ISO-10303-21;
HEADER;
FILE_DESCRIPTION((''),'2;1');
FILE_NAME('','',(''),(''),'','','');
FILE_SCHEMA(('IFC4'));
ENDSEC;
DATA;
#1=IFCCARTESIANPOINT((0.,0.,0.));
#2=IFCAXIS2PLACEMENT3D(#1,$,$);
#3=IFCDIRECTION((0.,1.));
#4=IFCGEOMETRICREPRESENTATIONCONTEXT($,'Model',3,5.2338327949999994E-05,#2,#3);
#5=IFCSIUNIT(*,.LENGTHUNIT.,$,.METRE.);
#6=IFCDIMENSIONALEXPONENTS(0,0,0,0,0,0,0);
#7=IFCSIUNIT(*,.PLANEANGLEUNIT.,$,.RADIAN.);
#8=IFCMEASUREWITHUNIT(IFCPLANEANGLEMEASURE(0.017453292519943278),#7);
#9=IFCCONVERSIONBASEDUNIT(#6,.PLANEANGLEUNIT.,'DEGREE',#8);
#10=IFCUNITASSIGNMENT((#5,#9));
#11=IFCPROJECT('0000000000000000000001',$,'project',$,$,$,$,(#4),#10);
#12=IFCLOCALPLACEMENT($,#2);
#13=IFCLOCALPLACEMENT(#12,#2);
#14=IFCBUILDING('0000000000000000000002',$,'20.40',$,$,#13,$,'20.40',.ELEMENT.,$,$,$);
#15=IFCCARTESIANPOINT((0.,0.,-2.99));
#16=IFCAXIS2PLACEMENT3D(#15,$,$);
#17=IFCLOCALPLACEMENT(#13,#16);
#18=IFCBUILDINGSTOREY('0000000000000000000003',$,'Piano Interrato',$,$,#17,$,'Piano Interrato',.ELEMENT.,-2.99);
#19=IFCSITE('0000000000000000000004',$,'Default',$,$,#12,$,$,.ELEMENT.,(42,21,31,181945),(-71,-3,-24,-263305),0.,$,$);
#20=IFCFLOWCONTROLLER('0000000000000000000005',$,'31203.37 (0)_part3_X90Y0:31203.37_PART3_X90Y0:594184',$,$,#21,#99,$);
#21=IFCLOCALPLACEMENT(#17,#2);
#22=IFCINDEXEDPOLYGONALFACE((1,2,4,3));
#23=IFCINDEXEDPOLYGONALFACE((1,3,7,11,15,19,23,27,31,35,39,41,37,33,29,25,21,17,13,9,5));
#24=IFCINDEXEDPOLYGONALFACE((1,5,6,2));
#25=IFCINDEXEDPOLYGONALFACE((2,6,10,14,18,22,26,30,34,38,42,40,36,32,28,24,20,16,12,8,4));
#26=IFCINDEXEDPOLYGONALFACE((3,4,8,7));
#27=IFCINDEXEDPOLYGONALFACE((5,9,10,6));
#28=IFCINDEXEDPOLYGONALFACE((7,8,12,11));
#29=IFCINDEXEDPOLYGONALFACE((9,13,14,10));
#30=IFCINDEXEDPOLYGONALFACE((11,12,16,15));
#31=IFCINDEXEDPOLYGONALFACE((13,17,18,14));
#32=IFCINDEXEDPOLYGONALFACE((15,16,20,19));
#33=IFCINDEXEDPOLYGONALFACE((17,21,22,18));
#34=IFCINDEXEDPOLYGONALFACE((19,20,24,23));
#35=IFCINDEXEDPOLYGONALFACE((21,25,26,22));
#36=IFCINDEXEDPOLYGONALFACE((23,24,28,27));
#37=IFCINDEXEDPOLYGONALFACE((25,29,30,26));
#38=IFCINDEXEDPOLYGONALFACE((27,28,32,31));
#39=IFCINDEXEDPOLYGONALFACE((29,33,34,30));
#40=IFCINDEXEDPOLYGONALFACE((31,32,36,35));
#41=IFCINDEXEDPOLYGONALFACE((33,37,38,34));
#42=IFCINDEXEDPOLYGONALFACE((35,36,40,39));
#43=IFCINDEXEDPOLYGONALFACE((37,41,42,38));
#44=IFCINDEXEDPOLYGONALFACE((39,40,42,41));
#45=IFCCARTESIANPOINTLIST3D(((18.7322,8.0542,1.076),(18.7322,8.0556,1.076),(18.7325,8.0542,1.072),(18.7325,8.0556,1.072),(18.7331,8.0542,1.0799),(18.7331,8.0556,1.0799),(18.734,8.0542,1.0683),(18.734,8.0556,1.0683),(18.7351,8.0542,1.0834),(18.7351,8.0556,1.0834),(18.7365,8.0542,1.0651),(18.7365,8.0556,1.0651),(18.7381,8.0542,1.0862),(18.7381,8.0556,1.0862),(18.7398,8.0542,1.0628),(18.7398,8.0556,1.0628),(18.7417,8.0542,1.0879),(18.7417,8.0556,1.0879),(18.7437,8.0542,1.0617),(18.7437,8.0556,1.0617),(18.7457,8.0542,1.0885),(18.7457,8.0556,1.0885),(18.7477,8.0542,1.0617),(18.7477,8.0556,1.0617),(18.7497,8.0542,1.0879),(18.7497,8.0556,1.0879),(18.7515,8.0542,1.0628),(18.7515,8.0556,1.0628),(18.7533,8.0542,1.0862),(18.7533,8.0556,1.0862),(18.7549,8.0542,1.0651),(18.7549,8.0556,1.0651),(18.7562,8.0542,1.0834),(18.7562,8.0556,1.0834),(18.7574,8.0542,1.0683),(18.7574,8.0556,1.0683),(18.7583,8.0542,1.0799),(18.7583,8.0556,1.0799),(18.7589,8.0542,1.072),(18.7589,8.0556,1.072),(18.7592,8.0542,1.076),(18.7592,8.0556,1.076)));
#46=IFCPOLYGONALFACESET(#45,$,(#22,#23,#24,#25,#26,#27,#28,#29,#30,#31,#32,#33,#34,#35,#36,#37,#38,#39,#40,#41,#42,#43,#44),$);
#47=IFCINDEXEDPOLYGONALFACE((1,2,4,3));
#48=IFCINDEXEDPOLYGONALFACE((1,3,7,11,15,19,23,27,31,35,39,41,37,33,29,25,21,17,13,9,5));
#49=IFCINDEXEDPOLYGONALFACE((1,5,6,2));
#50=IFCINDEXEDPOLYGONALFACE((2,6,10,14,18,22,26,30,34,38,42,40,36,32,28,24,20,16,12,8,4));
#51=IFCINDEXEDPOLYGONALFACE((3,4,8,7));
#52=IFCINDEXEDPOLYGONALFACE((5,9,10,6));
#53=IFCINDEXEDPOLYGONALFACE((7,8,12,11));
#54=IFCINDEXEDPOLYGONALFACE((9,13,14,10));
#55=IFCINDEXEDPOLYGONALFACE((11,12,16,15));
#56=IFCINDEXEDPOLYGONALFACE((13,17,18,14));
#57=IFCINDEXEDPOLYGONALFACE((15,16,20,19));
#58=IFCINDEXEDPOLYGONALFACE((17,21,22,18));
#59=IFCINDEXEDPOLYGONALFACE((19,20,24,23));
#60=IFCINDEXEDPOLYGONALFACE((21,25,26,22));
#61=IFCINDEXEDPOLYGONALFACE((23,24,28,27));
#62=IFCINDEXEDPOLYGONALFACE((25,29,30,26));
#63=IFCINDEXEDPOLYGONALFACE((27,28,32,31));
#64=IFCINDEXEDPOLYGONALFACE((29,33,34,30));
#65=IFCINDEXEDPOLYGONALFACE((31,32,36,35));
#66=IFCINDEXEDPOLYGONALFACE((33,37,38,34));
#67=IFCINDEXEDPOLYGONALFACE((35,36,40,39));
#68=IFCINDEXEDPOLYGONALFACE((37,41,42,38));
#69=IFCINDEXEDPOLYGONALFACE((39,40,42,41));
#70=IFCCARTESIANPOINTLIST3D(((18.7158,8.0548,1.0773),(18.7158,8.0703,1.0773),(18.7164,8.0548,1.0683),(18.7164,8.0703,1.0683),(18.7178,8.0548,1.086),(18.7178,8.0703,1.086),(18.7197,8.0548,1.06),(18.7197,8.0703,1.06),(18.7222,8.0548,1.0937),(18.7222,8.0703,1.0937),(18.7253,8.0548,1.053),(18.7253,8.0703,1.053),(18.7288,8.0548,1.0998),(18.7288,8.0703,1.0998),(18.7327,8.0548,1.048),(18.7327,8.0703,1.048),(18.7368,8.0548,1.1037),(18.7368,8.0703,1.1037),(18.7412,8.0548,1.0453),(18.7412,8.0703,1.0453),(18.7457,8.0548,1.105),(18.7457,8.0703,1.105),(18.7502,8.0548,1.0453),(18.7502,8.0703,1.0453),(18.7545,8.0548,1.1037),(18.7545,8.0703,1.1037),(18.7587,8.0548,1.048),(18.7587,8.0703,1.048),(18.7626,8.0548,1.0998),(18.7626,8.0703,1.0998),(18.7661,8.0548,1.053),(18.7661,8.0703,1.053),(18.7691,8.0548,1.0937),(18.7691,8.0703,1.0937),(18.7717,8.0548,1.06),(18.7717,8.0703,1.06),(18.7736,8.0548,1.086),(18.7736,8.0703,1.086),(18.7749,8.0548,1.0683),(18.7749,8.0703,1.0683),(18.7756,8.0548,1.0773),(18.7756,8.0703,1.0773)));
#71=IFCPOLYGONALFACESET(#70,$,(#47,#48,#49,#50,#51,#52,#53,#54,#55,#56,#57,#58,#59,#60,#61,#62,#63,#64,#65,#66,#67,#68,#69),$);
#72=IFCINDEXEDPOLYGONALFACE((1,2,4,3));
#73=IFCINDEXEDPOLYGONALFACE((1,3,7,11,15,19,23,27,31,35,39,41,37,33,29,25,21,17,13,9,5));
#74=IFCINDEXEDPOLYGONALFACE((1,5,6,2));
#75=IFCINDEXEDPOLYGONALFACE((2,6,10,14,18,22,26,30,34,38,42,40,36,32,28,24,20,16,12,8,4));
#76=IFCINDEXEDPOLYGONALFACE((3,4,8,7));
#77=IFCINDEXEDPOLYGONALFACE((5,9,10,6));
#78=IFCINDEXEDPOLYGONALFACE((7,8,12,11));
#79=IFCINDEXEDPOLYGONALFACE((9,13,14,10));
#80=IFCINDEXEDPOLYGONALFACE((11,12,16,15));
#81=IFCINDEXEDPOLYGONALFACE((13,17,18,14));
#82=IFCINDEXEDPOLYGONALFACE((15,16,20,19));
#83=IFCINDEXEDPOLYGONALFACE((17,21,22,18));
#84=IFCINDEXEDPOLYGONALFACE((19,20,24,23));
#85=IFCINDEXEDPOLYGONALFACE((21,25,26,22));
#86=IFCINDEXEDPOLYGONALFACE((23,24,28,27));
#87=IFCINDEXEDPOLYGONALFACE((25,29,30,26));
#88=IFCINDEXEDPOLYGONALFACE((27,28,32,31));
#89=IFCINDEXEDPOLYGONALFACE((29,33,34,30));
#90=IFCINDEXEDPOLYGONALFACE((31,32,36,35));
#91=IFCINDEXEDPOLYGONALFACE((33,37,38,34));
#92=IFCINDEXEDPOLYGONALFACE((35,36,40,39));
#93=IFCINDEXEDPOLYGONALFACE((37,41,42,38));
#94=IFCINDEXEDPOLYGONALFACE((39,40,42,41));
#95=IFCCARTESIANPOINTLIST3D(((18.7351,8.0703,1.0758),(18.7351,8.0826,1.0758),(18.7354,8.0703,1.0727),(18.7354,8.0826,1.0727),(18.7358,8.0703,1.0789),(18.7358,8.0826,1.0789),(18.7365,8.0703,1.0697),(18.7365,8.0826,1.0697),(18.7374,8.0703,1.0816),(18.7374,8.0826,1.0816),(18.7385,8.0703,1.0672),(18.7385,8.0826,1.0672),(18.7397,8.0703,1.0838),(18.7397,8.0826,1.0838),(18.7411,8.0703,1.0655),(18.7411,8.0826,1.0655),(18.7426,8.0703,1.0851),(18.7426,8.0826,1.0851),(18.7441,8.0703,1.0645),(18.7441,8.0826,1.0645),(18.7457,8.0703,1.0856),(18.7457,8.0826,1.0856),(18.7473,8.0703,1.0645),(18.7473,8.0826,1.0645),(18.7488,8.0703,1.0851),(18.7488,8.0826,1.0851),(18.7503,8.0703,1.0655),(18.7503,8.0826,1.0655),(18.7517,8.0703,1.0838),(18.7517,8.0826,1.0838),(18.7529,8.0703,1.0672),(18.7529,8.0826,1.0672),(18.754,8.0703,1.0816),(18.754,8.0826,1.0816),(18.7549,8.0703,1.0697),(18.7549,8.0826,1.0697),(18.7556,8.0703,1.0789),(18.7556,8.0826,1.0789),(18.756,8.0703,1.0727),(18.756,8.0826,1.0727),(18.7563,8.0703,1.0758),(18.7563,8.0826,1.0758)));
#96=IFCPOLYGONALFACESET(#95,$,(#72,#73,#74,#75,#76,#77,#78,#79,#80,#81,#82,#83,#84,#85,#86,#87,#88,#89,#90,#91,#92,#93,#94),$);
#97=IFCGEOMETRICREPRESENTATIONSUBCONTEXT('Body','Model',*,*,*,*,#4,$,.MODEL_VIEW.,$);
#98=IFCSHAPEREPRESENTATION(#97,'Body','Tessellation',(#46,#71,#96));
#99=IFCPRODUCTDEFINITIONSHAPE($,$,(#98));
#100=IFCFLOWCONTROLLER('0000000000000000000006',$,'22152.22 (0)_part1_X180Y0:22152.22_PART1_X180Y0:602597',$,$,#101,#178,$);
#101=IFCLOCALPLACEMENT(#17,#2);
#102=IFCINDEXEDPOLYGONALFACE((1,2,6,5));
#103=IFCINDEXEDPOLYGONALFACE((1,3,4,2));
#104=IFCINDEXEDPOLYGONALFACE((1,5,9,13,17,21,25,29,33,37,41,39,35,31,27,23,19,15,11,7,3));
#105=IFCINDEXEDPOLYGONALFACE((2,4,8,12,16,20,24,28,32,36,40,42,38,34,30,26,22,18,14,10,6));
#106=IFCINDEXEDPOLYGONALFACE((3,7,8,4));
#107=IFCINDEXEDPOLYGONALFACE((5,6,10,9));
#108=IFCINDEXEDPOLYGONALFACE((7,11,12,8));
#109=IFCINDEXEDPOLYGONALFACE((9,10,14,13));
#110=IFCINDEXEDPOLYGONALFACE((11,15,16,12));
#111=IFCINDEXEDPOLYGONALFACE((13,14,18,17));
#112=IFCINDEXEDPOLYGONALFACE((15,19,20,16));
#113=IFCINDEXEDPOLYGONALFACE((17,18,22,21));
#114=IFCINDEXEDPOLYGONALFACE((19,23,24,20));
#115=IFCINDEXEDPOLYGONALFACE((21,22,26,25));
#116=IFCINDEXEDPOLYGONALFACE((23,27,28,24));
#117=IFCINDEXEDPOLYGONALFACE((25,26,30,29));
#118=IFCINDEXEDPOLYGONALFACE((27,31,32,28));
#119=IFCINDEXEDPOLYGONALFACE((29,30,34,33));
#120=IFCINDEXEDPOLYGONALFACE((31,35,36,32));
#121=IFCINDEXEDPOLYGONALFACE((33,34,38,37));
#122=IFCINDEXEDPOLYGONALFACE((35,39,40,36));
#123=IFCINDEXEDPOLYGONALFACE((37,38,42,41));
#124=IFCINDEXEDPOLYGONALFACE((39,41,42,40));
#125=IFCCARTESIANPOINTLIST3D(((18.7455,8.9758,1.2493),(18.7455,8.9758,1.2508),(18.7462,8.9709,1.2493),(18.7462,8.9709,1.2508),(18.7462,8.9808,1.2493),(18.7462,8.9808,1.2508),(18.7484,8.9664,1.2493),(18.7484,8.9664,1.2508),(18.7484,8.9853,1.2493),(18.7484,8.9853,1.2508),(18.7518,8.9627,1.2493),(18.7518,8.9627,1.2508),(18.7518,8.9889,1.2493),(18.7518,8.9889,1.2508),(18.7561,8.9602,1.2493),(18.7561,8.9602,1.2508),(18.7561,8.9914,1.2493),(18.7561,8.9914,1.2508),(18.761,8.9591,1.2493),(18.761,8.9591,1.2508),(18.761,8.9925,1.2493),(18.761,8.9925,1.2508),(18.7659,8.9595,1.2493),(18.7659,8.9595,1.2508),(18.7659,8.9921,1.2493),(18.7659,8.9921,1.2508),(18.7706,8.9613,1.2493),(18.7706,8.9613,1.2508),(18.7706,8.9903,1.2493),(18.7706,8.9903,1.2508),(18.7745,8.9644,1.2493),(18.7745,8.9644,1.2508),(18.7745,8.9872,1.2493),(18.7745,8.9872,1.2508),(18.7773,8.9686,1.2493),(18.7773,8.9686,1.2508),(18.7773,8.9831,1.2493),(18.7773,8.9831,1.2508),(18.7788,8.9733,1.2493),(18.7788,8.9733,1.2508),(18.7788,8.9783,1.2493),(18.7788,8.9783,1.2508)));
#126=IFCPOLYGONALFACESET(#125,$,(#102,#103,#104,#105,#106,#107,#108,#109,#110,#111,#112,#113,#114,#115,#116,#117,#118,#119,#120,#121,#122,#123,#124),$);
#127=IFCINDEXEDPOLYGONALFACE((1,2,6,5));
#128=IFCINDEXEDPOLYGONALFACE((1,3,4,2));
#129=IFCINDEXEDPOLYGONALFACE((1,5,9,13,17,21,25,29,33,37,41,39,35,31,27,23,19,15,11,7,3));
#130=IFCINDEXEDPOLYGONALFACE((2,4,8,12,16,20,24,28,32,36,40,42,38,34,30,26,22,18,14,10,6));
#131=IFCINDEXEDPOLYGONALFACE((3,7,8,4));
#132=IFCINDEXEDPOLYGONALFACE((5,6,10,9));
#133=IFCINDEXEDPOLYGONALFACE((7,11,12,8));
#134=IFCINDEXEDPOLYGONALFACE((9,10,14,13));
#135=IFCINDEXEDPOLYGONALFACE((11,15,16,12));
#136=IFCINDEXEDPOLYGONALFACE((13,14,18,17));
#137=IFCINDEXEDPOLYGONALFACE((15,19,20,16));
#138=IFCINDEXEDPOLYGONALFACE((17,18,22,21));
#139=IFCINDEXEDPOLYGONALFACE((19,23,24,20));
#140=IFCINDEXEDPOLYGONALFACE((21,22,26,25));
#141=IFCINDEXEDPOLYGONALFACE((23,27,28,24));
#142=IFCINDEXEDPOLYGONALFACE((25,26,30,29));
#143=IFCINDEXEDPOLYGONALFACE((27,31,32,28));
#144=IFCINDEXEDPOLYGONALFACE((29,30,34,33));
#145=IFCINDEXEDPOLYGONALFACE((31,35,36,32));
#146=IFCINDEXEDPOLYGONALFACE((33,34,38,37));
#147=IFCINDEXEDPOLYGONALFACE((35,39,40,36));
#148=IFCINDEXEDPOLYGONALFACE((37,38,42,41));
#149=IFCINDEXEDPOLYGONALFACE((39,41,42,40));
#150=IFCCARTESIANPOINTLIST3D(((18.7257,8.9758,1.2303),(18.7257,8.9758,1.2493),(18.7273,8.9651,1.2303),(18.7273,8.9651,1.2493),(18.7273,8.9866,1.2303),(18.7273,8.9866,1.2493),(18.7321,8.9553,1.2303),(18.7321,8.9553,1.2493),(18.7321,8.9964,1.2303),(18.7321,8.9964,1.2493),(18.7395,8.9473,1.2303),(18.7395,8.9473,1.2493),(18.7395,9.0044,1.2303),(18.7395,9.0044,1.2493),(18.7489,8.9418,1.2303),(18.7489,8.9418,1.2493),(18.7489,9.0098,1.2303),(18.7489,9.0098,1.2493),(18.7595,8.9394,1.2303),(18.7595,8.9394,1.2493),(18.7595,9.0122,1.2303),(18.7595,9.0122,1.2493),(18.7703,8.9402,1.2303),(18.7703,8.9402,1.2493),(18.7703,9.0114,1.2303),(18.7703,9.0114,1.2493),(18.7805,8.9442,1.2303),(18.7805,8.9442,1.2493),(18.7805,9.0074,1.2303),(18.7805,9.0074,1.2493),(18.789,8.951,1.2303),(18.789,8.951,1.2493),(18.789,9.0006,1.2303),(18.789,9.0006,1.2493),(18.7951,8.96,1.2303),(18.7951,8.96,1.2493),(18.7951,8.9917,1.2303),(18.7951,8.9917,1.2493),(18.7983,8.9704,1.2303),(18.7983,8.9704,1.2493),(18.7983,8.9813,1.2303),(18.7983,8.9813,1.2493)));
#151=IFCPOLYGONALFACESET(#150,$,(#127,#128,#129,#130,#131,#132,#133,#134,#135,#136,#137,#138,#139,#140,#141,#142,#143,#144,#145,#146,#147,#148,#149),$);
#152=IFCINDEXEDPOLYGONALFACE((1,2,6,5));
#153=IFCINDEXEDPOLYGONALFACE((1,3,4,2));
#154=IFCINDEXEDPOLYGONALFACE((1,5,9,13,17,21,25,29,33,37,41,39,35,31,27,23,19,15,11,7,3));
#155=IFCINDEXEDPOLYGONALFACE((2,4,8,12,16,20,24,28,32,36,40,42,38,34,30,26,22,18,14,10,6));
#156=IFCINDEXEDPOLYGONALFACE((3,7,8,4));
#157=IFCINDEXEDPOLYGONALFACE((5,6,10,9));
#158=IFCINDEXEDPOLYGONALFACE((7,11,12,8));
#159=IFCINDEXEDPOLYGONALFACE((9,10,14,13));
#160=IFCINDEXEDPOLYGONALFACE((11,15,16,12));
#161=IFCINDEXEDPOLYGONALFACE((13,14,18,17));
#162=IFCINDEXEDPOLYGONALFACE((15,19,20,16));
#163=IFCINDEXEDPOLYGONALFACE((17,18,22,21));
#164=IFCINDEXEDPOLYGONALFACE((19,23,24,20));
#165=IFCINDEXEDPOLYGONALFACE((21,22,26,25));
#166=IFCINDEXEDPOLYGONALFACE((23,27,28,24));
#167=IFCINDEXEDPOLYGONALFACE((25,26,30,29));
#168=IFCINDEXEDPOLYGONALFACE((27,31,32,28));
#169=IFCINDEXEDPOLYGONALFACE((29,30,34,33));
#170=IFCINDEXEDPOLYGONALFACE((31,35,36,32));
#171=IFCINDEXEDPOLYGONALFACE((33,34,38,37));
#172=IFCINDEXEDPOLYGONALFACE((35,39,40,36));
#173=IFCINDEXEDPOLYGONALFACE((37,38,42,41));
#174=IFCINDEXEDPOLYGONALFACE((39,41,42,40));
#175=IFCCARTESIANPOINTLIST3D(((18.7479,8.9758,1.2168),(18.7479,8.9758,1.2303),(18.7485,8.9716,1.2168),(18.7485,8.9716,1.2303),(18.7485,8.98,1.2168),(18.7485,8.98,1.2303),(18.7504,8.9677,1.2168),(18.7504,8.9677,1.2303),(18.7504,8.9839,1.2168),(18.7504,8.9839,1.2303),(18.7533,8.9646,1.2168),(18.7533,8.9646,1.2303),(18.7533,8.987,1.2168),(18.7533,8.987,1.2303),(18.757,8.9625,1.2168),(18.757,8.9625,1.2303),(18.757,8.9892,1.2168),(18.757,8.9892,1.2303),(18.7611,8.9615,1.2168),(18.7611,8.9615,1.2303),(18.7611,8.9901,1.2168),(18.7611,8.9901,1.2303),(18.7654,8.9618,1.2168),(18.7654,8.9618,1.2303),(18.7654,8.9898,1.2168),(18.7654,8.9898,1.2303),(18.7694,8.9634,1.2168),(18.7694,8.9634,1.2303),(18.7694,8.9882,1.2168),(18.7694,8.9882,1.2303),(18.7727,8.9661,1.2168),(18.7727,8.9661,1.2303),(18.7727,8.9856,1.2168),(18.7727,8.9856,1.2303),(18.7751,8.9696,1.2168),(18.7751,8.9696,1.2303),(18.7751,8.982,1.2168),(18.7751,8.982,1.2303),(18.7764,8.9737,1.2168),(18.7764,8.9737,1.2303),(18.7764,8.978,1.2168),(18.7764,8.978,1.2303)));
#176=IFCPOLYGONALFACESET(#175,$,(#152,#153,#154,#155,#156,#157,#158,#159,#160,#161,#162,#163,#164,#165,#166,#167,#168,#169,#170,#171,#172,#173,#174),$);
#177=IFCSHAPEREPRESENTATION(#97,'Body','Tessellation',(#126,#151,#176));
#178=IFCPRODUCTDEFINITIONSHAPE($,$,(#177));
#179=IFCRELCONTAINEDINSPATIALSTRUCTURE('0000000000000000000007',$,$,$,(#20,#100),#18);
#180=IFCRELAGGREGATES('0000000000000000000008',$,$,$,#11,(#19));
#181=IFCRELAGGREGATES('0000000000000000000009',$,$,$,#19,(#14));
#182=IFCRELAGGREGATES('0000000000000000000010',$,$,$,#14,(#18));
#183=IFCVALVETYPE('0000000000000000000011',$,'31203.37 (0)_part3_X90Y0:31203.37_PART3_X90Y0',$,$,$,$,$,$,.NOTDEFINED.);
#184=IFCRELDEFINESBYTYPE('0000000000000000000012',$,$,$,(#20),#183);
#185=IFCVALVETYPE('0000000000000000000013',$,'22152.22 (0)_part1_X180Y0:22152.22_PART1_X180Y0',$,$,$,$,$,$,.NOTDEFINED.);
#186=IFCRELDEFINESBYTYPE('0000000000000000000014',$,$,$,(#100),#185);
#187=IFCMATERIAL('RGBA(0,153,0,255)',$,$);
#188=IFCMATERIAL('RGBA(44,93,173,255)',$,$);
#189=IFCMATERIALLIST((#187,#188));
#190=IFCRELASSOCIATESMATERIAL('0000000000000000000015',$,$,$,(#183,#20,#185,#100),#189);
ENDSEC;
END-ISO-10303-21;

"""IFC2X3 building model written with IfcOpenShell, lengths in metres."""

from ifc_helpers import new_model, entity, si_unit, converted_unit, direction, frame, frame_2d, origin, place, context, subcontext, project, spatial, circle, extrude, source, transform, mapped, material, material_list, type_object, type_shapes, element, save


model = new_model("IFC2X3")

# Units and contexts
model_context = context("Model", 3, precision=5.2338327949999994e-05, world=origin(), true_north=direction((0.0, 1.0)))
body_context = subcontext(model_context, "Body", "Model", "MODEL_VIEW")
ifc_project = project(units=[si_unit("LENGTHUNIT", "METRE"), converted_unit("PLANEANGLEUNIT", "DEGREE", entity("IfcPlaneAngleMeasure", 0.017453292519943278), si_unit("PLANEANGLEUNIT", "RADIAN"), dimensions=[0, 0, 0, 0, 0, 0, 0])], contexts=[model_context])

# Site, building, storey
site_placement = place(None, origin())
site = spatial("IfcSite", under=ifc_project, at=site_placement, Name="Default", CompositionType="ELEMENT", RefLatitude=(42, 21, 31, 181945), RefLongitude=(-71, -3, -24, -263305), RefElevation=0.0)
building_placement = place(site_placement, origin())
building = spatial("IfcBuilding", under=site, at=building_placement, Name="20.40", LongName="20.40", CompositionType="ELEMENT")
storey_placement = place(building_placement, frame((0.0, 0.0, -2.99)))
storey = spatial("IfcBuildingStorey", under=building, at=storey_placement, Name="Piano Interrato", LongName="Piano Interrato", CompositionType="ELEMENT", Elevation=-2.99)

# Flow controllers
ifc_material_1 = material(Name="RGBA(0,153,0,255)")
ifc_material_2 = material(Name="RGBA(44,93,173,255)")
ifc_material_list_1 = material_list([ifc_material_1, ifc_material_2])
valve_type_1 = type_object("IfcValveType", Name="31203.37 (0)_part3_X90Y0:31203.37_PART3_X90Y0", PredefinedType="NOTDEFINED", material=ifc_material_list_1)
shared_shape_1 = source(origin(), body_context, "Body", "SweptSolid", [
    extrude(circle(Radius=0.0135, at=frame_2d((0.0, 0.0), x_axis=(1.0, 0.0))), frame((0.0, -0.0284, 0.0), z_axis=(0.0, 1.0, 0.0), x_axis=(0.0, 0.0, 1.0)), (0.0, 0.0, 1.0), 0.0014),
    extrude(circle(Radius=0.03, at=frame_2d((0.0, 0.0), x_axis=(1.0, 0.0))), frame((0.0, -0.0278, 0.0), z_axis=(0.0, 1.0, 0.0), x_axis=(0.0, 0.0, 1.0)), (0.0, 0.0, 1.0), 0.0155),
    extrude(circle(Radius=0.0106, at=frame_2d((0.0, 0.0), x_axis=(1.0, 0.0))), frame((0.0, -0.0123, 0.0), z_axis=(0.0, 1.0, 0.0), x_axis=(0.0, 0.0, 1.0)), (0.0, 0.0, 1.0), 0.0123),
])
type_shapes(valve_type_1, [shared_shape_1])
flow_controller_1_placement = place(storey_placement, frame((18.7457, 8.0826, 1.075)))
element("IfcFlowController", 1, at=flow_controller_1_placement, inside=storey, type_object=valve_type_1, material=ifc_material_list_1, Name="31203.37 (0)_part3_X90Y0:31203.37_PART3_X90Y0:594184", context=body_context, shape_type="MappedRepresentation", body=[
    mapped(shared_shape_1, transform((0.0, 0.0, 0.0), scale=1.0)),
])
valve_type_2 = type_object("IfcValveType", Name="22152.22 (0)_part1_X180Y0:22152.22_PART1_X180Y0", PredefinedType="NOTDEFINED", material=ifc_material_list_1)
shared_shape_2 = source(origin(), body_context, "Body", "SweptSolid", [
    extrude(circle(Radius=0.0168, at=frame_2d((0.0, 0.0), x_axis=(1.0, 0.0))), frame((0.0, 0.0, -0.034), z_axis=(0.0, 0.0, 1.0), x_axis=(0.0, -1.0, 0.0)), (0.0, 0.0, 1.0), 0.0015),
    extrude(circle(Radius=0.0365, at=frame_2d((0.0, 0.0), x_axis=(1.0, 0.0))), frame((0.0, 0.0, -0.0325), z_axis=(0.0, 0.0, 1.0), x_axis=(0.0, -1.0, 0.0)), (0.0, 0.0, 1.0), 0.019),
    extrude(circle(Radius=0.0144, at=frame_2d((0.0, 0.0), x_axis=(1.0, 0.0))), frame((0.0, 0.0, -0.0135), z_axis=(0.0, 0.0, 1.0), x_axis=(0.0, -1.0, 0.0)), (0.0, 0.0, 1.0), 0.0135),
])
type_shapes(valve_type_2, [shared_shape_2])
flow_controller_2_placement = place(storey_placement, frame((18.7622, 8.9758, 1.2168), z_axis=(0.0, 0.0, -1.0), x_axis=(0.0, 1.0, 0.0)))
element("IfcFlowController", 2, at=flow_controller_2_placement, inside=storey, type_object=valve_type_2, material=ifc_material_list_1, Name="22152.22 (0)_part1_X180Y0:22152.22_PART1_X180Y0:602597", context=body_context, shape_type="MappedRepresentation", body=[
    mapped(shared_shape_2, transform((0.0, 0.0, 0.0), scale=1.0)),
])

save(model, "model.ifc")
